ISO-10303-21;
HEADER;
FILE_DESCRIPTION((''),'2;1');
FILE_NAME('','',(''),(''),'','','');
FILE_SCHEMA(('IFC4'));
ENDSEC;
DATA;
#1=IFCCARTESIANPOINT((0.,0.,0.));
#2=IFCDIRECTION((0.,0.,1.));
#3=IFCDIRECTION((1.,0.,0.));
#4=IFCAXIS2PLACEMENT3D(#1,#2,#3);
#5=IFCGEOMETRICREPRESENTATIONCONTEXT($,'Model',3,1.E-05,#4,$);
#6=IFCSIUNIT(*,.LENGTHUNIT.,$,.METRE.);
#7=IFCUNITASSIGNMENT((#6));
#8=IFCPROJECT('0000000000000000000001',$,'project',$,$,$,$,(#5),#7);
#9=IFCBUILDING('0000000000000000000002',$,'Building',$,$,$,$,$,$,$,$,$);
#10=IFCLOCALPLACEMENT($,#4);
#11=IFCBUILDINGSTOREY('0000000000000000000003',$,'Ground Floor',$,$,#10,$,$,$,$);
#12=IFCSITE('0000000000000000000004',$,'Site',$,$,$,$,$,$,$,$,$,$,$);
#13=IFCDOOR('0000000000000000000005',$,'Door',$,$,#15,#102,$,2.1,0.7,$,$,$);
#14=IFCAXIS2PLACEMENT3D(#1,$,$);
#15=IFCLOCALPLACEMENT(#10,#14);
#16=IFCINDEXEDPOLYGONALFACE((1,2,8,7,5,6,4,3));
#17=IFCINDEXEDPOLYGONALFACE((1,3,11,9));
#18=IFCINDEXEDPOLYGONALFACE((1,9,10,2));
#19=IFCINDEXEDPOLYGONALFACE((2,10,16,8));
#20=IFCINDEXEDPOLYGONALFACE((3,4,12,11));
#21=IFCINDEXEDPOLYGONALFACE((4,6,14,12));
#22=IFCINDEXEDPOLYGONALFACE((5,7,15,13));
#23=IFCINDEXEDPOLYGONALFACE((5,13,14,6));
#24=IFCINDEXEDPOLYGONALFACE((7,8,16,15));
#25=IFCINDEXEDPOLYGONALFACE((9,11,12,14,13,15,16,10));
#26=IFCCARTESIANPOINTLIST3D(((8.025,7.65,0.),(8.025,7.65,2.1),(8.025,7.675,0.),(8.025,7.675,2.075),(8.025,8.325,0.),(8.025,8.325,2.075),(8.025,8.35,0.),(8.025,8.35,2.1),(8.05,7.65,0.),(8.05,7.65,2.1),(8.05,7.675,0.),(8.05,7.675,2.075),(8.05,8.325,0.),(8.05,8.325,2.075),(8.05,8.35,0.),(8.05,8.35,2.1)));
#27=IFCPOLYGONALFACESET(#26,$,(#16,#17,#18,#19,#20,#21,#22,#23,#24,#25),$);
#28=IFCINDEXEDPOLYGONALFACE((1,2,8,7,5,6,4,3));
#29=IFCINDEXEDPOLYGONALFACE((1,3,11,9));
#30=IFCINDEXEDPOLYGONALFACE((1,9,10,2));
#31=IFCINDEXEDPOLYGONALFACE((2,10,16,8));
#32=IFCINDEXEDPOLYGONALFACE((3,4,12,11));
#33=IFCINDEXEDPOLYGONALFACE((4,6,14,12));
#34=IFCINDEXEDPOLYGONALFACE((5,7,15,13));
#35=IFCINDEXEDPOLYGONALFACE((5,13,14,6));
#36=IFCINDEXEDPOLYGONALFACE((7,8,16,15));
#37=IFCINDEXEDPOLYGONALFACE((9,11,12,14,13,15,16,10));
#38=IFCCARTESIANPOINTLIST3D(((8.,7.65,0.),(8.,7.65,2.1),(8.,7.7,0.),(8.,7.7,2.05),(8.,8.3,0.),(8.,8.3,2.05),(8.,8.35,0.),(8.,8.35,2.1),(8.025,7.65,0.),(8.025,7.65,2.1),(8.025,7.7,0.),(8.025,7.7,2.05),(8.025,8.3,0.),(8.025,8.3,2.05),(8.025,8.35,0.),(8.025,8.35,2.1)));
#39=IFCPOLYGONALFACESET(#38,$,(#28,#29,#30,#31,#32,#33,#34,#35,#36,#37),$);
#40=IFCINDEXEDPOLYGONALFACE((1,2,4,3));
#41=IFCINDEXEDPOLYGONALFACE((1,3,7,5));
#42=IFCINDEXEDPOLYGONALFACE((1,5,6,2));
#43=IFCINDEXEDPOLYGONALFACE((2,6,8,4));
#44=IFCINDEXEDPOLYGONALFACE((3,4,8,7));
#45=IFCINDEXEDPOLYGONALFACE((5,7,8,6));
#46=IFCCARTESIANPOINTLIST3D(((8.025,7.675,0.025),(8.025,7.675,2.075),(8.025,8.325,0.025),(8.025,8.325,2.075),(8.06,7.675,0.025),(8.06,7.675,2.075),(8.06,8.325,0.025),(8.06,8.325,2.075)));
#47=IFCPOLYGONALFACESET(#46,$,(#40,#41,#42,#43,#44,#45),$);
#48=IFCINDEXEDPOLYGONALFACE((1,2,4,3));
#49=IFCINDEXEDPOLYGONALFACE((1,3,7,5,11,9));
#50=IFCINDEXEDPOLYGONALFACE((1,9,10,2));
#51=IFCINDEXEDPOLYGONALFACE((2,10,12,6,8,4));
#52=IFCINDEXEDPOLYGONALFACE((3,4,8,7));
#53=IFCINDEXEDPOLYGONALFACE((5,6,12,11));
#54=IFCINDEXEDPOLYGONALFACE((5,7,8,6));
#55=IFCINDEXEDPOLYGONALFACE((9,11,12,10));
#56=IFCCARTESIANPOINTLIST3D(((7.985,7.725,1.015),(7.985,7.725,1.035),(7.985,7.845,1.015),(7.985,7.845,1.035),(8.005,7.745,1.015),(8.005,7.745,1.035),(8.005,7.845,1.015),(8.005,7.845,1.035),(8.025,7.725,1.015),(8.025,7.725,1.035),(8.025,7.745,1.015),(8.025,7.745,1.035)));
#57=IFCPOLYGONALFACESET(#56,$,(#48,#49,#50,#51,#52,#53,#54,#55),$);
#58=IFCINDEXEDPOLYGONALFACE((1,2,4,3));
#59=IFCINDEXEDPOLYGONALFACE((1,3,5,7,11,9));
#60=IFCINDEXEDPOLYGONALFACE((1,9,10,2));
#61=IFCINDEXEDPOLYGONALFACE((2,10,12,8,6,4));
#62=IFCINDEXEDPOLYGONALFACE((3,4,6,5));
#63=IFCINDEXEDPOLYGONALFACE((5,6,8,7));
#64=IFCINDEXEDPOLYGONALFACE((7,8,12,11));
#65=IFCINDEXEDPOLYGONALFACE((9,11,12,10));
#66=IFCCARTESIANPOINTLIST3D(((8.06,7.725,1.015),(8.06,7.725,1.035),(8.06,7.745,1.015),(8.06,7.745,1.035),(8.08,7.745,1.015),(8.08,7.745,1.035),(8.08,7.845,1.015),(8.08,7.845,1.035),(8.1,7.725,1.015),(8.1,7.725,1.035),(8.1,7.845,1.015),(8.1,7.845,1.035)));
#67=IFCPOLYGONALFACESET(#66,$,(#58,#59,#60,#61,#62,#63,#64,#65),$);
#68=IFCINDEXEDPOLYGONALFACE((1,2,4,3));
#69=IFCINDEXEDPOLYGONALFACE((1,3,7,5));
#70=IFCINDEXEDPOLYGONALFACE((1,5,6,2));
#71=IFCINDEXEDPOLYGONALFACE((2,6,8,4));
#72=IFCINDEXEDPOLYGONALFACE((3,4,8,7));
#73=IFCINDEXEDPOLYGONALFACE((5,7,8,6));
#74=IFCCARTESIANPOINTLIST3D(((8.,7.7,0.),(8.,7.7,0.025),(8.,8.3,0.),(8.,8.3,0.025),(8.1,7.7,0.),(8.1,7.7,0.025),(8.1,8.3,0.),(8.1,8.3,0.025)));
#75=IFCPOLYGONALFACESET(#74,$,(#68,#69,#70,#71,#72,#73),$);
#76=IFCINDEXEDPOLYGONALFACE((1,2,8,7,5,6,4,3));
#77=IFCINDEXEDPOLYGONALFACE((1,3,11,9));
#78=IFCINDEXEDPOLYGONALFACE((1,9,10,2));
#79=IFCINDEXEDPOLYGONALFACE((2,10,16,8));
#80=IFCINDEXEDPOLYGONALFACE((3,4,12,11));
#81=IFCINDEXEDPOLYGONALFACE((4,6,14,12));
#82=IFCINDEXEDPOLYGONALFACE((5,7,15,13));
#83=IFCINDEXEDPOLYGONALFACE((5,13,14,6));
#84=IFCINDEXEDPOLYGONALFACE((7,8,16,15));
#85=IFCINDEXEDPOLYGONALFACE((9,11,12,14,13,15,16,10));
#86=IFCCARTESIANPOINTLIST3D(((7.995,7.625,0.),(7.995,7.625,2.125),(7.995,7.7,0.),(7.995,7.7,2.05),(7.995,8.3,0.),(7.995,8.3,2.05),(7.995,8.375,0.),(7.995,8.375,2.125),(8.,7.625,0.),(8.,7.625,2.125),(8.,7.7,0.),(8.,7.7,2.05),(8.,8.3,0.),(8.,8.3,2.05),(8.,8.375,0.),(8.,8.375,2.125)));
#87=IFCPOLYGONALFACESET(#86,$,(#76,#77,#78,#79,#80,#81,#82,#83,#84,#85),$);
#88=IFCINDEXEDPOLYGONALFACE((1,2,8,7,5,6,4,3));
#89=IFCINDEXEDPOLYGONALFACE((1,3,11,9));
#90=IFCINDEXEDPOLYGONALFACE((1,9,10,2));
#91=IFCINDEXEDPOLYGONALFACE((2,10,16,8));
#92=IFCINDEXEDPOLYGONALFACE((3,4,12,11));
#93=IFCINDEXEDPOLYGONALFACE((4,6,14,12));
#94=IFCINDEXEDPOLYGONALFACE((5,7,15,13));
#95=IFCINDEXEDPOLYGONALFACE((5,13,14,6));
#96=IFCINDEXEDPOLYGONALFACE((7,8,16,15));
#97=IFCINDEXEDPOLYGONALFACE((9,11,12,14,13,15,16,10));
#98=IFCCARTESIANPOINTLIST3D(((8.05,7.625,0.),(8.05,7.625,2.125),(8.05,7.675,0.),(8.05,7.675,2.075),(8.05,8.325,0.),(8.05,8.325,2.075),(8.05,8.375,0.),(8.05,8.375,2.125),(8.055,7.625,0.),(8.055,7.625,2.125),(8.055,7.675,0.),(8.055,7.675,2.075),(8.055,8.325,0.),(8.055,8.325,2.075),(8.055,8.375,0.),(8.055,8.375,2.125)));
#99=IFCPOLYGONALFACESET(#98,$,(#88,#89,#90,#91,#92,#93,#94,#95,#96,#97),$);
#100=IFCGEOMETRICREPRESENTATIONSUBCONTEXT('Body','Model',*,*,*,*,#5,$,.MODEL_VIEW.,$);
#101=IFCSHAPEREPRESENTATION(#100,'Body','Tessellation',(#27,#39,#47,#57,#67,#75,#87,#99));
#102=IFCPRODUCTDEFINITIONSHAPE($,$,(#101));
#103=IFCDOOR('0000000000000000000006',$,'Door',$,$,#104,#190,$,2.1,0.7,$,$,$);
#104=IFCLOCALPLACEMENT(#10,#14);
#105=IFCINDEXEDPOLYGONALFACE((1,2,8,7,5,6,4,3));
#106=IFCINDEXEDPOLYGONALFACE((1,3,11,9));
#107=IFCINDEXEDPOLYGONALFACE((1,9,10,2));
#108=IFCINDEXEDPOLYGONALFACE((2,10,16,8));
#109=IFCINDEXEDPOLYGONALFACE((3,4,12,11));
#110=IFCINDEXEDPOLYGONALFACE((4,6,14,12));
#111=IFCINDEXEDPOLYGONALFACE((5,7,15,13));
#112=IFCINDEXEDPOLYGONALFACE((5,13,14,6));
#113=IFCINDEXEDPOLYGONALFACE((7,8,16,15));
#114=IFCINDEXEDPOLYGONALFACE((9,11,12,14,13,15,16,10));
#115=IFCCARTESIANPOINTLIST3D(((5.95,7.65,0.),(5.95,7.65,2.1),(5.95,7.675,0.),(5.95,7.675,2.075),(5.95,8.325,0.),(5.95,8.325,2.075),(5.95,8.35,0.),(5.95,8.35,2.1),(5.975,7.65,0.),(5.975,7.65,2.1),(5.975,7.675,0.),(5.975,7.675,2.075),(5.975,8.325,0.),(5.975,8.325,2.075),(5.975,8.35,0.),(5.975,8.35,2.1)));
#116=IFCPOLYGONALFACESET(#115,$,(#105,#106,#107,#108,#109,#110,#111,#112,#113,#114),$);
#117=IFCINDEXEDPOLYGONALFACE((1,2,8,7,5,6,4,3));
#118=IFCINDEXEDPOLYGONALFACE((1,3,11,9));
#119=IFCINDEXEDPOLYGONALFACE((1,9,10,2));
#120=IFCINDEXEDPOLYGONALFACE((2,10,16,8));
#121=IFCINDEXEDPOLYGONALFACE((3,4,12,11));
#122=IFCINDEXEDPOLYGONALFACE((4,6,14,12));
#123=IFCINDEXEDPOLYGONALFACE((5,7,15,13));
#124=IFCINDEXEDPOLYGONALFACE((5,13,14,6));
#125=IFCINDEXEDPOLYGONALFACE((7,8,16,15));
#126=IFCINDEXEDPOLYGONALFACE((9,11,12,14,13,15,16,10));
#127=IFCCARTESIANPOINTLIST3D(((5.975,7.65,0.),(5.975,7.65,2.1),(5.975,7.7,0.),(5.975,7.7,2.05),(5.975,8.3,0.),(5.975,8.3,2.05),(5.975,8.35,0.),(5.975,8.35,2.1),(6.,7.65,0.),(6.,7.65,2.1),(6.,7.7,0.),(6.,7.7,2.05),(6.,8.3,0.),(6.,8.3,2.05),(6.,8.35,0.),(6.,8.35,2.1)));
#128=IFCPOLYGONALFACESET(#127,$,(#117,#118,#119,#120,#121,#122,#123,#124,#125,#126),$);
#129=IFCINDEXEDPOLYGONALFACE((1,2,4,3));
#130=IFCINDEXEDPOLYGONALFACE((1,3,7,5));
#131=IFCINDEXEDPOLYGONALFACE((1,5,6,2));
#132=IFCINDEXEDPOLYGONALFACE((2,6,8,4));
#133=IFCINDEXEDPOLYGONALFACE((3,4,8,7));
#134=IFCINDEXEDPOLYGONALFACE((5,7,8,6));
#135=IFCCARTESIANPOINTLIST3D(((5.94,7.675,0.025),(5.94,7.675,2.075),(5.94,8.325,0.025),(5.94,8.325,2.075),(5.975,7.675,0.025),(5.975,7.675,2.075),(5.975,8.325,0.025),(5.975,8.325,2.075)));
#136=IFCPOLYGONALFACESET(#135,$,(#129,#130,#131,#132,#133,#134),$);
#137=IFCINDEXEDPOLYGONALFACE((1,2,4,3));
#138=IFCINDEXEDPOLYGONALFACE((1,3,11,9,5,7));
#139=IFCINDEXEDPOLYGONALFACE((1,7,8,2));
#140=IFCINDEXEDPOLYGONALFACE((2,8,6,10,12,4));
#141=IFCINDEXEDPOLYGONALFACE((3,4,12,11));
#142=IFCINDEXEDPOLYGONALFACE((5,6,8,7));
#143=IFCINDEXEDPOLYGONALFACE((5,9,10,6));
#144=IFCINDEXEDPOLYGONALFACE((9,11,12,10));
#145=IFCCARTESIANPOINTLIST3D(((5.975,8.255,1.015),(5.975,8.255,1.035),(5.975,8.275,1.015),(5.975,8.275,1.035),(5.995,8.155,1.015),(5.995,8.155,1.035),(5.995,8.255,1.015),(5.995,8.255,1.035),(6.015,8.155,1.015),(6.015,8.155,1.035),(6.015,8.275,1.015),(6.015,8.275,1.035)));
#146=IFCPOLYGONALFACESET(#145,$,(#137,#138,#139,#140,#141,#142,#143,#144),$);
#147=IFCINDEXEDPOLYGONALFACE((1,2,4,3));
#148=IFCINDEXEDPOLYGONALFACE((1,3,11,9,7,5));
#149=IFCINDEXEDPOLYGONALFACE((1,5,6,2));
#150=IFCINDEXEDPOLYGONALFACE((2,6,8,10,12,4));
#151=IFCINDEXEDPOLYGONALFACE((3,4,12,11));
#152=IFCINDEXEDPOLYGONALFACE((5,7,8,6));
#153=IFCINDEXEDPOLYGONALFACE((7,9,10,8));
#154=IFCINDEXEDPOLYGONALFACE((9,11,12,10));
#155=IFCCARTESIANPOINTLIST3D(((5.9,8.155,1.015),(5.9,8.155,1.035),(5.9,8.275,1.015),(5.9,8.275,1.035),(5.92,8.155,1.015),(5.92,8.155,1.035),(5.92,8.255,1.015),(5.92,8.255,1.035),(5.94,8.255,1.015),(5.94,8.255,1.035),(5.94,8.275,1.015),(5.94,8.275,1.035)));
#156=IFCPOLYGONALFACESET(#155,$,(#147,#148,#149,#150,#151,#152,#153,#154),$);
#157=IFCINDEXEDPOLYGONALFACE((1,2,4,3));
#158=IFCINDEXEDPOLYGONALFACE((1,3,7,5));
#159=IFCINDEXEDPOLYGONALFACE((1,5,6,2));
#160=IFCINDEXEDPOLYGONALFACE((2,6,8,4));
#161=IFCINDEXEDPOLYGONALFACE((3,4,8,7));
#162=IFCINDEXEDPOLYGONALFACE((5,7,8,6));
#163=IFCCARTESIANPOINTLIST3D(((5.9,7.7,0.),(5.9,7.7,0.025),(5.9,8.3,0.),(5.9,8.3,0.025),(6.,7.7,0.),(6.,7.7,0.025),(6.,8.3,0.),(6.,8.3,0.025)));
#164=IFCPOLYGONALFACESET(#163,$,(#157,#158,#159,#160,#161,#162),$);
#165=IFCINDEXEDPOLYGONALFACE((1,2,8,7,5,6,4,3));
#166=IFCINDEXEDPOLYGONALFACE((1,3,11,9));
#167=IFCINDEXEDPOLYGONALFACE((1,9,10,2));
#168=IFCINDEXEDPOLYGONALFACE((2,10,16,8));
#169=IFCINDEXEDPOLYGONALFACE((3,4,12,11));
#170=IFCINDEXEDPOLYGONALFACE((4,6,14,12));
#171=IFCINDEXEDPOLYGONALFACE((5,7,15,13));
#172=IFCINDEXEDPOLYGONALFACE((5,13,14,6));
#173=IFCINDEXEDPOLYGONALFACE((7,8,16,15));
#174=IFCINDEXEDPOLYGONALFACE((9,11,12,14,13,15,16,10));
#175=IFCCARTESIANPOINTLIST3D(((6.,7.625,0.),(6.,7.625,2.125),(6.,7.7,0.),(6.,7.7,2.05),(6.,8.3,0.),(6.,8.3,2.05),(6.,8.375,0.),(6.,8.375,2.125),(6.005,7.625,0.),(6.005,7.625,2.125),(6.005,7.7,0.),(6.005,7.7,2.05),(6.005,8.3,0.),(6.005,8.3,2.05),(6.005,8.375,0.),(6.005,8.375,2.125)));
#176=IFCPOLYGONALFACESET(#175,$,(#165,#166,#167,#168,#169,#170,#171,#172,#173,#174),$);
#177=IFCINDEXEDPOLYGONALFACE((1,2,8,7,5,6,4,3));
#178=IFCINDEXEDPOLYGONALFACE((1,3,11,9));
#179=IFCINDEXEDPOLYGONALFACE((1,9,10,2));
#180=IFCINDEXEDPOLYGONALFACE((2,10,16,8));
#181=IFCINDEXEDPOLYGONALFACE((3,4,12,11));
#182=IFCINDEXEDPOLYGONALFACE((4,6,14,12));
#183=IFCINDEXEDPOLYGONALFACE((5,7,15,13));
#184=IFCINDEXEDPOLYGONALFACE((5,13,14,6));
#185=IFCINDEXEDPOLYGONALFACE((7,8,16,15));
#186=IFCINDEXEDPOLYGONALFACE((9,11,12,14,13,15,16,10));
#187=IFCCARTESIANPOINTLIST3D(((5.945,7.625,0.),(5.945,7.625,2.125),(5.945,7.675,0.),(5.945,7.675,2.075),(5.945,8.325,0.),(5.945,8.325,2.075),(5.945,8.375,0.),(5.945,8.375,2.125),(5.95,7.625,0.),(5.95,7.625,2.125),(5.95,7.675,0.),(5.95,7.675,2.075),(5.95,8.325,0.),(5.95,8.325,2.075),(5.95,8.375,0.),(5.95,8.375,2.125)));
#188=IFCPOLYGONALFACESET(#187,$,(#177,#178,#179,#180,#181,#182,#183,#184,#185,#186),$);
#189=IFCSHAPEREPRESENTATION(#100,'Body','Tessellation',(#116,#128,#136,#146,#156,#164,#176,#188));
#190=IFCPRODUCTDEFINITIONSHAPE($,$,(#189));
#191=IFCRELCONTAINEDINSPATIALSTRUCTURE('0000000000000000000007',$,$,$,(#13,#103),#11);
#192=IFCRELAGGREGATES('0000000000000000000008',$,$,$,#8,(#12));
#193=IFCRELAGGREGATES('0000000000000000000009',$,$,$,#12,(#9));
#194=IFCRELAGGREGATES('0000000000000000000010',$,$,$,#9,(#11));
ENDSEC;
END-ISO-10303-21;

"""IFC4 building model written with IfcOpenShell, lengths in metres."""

from ifc_helpers import new_model, si_unit, frame, origin_with_axes, place, context, subcontext, project, spatial, line, indexed_curve, outline, extrude, element, save


model = new_model("IFC4")

# Units and contexts
model_context = context("Model", 3, precision=1e-05, world=origin_with_axes())
body_context = subcontext(model_context, "Body", "Model", "MODEL_VIEW")
ifc_project = project(units=[si_unit("LENGTHUNIT", "METRE")], contexts=[model_context])

# Site, building, storey
site = spatial("IfcSite", under=ifc_project, Name="Site")
building = spatial("IfcBuilding", under=site, Name="Building")
storey_placement = place(None, origin_with_axes())
storey = spatial("IfcBuildingStorey", under=building, at=storey_placement, Name="Ground Floor")

# Doors
door_1_placement = place(storey_placement, frame((8.0, 8.35, 0.0), z_axis=(0.0, 0.0, 1.0), x_axis=(0.0, -1.0, 0.0)))
element("IfcDoor", 1, at=door_1_placement, inside=storey, Name="Door", OverallHeight=2.1, OverallWidth=0.7, context=body_context, shape_type="SweptSolid", body=[
    extrude(outline(indexed_curve([(0.0, 0.0), (0.0, 2.1), (0.7, 2.1), (0.7, 0.0), (0.675, 0.0), (0.675, 2.075), (0.025, 2.075), (0.025, 0.0)], segments=[line(1, 2, 3, 4, 5, 6, 7, 8, 1)])), frame((0.0, 0.025, 0.0), z_axis=(0.0, -1.0, 0.0), x_axis=(1.0, 0.0, 0.0)), (0.0, 0.0, -1.0), 0.025),
    extrude(outline(indexed_curve([(0.0, 0.0), (0.0, 2.1), (0.7, 2.1), (0.7, 0.0), (0.65, 0.0), (0.65, 2.05), (0.05, 2.05), (0.05, 0.0)], segments=[line(1, 2, 3, 4, 5, 6, 7, 8, 1)])), frame((0.0, 0.0, 0.0), z_axis=(0.0, -1.0, 0.0), x_axis=(1.0, 0.0, 0.0)), (0.0, 0.0, -1.0), 0.025),
    extrude(outline(indexed_curve([(0.0, 0.0), (0.65, 0.0), (0.65, 0.035), (0.0, 0.035)], segments=[line(1, 2, 3, 4, 1)])), frame((0.025, 0.025, 0.025), z_axis=(0.0, 0.0, 1.0), x_axis=(1.0, 0.0, 0.0)), (0.0, 0.0, 1.0), 2.05),
    extrude(outline(indexed_curve([(0.0, 0.0), (0.0, -0.04), (-0.12, -0.04), (-0.12, -0.02), (-0.02, -0.02), (-0.02, 0.0)], segments=[line(1, 2, 3, 4, 5, 6, 1)])), frame((0.625, 0.025, 1.015), z_axis=(0.0, 0.0, 1.0), x_axis=(1.0, 0.0, 0.0)), (0.0, 0.0, 1.0), 0.02),
    extrude(outline(indexed_curve([(0.0, 0.0), (0.0, 0.04), (-0.12, 0.04), (-0.12, 0.02), (-0.02, 0.02), (-0.02, 0.0)], segments=[line(1, 2, 3, 4, 5, 6, 1)])), frame((0.625, 0.06, 1.015), z_axis=(0.0, 0.0, 1.0), x_axis=(1.0, 0.0, 0.0)), (0.0, 0.0, 1.0), 0.02),
    extrude(outline(indexed_curve([(0.0, 0.0), (0.6, 0.0), (0.6, 0.1), (0.0, 0.1)], segments=[line(1, 2, 3, 4, 1)])), frame((0.05, 0.0, 0.0), z_axis=(0.0, 0.0, 1.0), x_axis=(1.0, 0.0, 0.0)), (0.0, 0.0, 1.0), 0.025),
    extrude(outline(indexed_curve([(0.0, 0.0), (0.0, 2.125), (0.75, 2.125), (0.75, 0.0), (0.675, 0.0), (0.675, 2.05), (0.075, 2.05), (0.075, 0.0)], segments=[line(1, 2, 3, 4, 5, 6, 7, 8, 1)])), frame((-0.025, -0.005, 0.0), z_axis=(0.0, -1.0, 0.0), x_axis=(1.0, 0.0, 0.0)), (0.0, 0.0, -1.0), 0.005),
    extrude(outline(indexed_curve([(0.0, 0.0), (0.0, 2.125), (0.75, 2.125), (0.75, 0.0), (0.7, 0.0), (0.7, 2.075), (0.05, 2.075), (0.05, 0.0)], segments=[line(1, 2, 3, 4, 5, 6, 7, 8, 1)])), frame((-0.025, 0.05, 0.0), z_axis=(0.0, -1.0, 0.0), x_axis=(1.0, 0.0, 0.0)), (0.0, 0.0, -1.0), 0.005),
])
door_2_placement = place(storey_placement, frame((6.0, 7.65, 0.0), z_axis=(0.0, 0.0, 1.0), x_axis=(0.0, 1.0, 0.0)))
element("IfcDoor", 2, at=door_2_placement, inside=storey, Name="Door", OverallHeight=2.1, OverallWidth=0.7, context=body_context, shape_type="SweptSolid", body=[
    extrude(outline(indexed_curve([(0.0, 0.0), (0.0, 2.1), (0.7, 2.1), (0.7, 0.0), (0.675, 0.0), (0.675, 2.075), (0.025, 2.075), (0.025, 0.0)], segments=[line(1, 2, 3, 4, 5, 6, 7, 8, 1)])), frame((0.0, 0.025, 0.0), z_axis=(0.0, -1.0, 0.0), x_axis=(1.0, 0.0, 0.0)), (0.0, 0.0, -1.0), 0.025),
    extrude(outline(indexed_curve([(0.0, 0.0), (0.0, 2.1), (0.7, 2.1), (0.7, 0.0), (0.65, 0.0), (0.65, 2.05), (0.05, 2.05), (0.05, 0.0)], segments=[line(1, 2, 3, 4, 5, 6, 7, 8, 1)])), frame((0.0, 0.0, 0.0), z_axis=(0.0, -1.0, 0.0), x_axis=(1.0, 0.0, 0.0)), (0.0, 0.0, -1.0), 0.025),
    extrude(outline(indexed_curve([(0.0, 0.0), (0.65, 0.0), (0.65, 0.035), (0.0, 0.035)], segments=[line(1, 2, 3, 4, 1)])), frame((0.025, 0.025, 0.025), z_axis=(0.0, 0.0, 1.0), x_axis=(1.0, 0.0, 0.0)), (0.0, 0.0, 1.0), 2.05),
    extrude(outline(indexed_curve([(0.0, 0.0), (0.0, -0.04), (-0.12, -0.04), (-0.12, -0.02), (-0.02, -0.02), (-0.02, 0.0)], segments=[line(1, 2, 3, 4, 5, 6, 1)])), frame((0.625, 0.025, 1.015), z_axis=(0.0, 0.0, 1.0), x_axis=(1.0, 0.0, 0.0)), (0.0, 0.0, 1.0), 0.02),
    extrude(outline(indexed_curve([(0.0, 0.0), (0.0, 0.04), (-0.12, 0.04), (-0.12, 0.02), (-0.02, 0.02), (-0.02, 0.0)], segments=[line(1, 2, 3, 4, 5, 6, 1)])), frame((0.625, 0.06, 1.015), z_axis=(0.0, 0.0, 1.0), x_axis=(1.0, 0.0, 0.0)), (0.0, 0.0, 1.0), 0.02),
    extrude(outline(indexed_curve([(0.0, 0.0), (0.6, 0.0), (0.6, 0.1), (0.0, 0.1)], segments=[line(1, 2, 3, 4, 1)])), frame((0.05, 0.0, 0.0), z_axis=(0.0, 0.0, 1.0), x_axis=(1.0, 0.0, 0.0)), (0.0, 0.0, 1.0), 0.025),
    extrude(outline(indexed_curve([(0.0, 0.0), (0.0, 2.125), (0.75, 2.125), (0.75, 0.0), (0.675, 0.0), (0.675, 2.05), (0.075, 2.05), (0.075, 0.0)], segments=[line(1, 2, 3, 4, 5, 6, 7, 8, 1)])), frame((-0.025, -0.005, 0.0), z_axis=(0.0, -1.0, 0.0), x_axis=(1.0, 0.0, 0.0)), (0.0, 0.0, -1.0), 0.005),
    extrude(outline(indexed_curve([(0.0, 0.0), (0.0, 2.125), (0.75, 2.125), (0.75, 0.0), (0.7, 0.0), (0.7, 2.075), (0.05, 2.075), (0.05, 0.0)], segments=[line(1, 2, 3, 4, 5, 6, 7, 8, 1)])), frame((-0.025, 0.05, 0.0), z_axis=(0.0, -1.0, 0.0), x_axis=(1.0, 0.0, 0.0)), (0.0, 0.0, -1.0), 0.005),
])

save(model, "model.ifc")
